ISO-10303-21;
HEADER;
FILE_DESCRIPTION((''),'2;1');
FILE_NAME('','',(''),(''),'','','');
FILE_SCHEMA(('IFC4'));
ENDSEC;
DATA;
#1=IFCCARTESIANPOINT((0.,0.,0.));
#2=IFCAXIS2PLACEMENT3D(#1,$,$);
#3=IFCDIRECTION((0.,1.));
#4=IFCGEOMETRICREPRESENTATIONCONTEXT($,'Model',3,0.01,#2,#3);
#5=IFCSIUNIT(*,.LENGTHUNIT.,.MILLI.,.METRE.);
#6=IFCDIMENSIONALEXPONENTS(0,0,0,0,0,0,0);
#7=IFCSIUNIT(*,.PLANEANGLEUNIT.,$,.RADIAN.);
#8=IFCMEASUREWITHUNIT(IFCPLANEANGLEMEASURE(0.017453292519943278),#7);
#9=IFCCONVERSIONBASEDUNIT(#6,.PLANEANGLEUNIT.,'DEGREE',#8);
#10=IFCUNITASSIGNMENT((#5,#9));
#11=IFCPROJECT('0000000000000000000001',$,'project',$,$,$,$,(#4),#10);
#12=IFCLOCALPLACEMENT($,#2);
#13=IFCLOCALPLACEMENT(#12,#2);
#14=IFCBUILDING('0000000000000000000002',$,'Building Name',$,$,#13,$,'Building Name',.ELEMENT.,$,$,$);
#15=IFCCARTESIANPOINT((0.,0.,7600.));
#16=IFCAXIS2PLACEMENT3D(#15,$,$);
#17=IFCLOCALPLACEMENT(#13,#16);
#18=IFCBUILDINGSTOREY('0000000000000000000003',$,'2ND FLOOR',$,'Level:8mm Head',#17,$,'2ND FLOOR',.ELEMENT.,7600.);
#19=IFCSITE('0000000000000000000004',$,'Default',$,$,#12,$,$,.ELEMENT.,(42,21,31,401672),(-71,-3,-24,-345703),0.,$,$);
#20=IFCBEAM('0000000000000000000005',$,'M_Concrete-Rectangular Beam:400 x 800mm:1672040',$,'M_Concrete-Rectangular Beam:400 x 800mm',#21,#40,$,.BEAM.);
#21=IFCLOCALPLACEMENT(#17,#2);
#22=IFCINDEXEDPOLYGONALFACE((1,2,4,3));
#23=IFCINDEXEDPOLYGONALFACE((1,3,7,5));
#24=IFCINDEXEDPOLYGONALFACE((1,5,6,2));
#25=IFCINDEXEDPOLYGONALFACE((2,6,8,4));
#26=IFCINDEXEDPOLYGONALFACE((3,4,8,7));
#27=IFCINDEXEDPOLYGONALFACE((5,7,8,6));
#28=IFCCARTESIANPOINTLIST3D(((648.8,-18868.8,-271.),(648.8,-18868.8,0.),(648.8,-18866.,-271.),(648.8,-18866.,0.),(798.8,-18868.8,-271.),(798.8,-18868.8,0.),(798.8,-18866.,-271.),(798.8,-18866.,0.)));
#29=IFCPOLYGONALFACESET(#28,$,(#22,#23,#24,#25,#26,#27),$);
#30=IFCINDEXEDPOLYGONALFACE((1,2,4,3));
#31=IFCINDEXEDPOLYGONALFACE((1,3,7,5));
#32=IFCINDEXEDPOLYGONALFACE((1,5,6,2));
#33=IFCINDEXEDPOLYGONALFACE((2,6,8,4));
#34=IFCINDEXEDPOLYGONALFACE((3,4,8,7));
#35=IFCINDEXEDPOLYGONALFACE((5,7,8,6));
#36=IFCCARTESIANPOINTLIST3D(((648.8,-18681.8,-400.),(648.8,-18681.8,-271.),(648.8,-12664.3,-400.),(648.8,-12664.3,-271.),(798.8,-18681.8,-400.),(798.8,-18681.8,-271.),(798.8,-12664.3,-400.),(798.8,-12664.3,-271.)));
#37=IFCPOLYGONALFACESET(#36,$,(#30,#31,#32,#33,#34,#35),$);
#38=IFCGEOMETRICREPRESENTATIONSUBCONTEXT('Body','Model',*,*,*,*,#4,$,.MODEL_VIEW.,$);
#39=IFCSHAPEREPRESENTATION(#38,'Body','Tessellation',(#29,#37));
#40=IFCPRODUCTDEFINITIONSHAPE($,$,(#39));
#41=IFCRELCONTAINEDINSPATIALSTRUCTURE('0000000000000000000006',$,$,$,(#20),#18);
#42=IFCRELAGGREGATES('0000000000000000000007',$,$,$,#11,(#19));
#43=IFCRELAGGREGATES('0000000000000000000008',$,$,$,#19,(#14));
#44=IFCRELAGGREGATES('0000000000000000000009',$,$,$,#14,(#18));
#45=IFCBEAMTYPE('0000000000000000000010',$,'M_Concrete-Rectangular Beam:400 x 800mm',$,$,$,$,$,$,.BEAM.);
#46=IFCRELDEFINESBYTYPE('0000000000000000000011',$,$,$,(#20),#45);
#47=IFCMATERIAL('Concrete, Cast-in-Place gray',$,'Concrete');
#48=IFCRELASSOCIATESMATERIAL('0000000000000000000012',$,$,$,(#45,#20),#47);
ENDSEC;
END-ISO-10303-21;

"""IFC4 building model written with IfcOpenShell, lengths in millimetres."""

from ifc_helpers import new_model, entity, si_unit, converted_unit, direction, frame, origin, place, context, subcontext, project, spatial, indexed_curve, outline, extrude, source, transform, mapped, material, type_object, type_shapes, element, save


model = new_model("IFC4")

# Units and contexts
model_context = context("Model", 3, precision=0.01, world=origin(), true_north=direction((0.0, 1.0)))
body_context = subcontext(model_context, "Body", "Model", "MODEL_VIEW")
ifc_project = project(units=[si_unit("LENGTHUNIT", "METRE", prefix="MILLI"), converted_unit("PLANEANGLEUNIT", "DEGREE", entity("IfcPlaneAngleMeasure", 0.017453292519943278), si_unit("PLANEANGLEUNIT", "RADIAN"), dimensions=[0, 0, 0, 0, 0, 0, 0])], contexts=[model_context])

# Site, building, storey
site_placement = place(None, origin())
site = spatial("IfcSite", under=ifc_project, at=site_placement, Name="Default", CompositionType="ELEMENT", RefLatitude=(42, 21, 31, 401672), RefLongitude=(-71, -3, -24, -345703), RefElevation=0.0)
building_placement = place(site_placement, origin())
building = spatial("IfcBuilding", under=site, at=building_placement, Name="Building Name", LongName="Building Name", CompositionType="ELEMENT")
storey_placement = place(building_placement, frame((0.0, 0.0, 7600.0)))
storey = spatial("IfcBuildingStorey", under=building, at=storey_placement, Name="2ND FLOOR", ObjectType="Level:8mm Head", LongName="2ND FLOOR", CompositionType="ELEMENT", Elevation=7600.0)

# Shared definitions
ifc_material_1 = material(Name="Concrete, Cast-in-Place gray", Category="Concrete")

# Beam
beam_type_1 = type_object("IfcBeamType", Name="M_Concrete-Rectangular Beam:400 x 800mm", PredefinedType="BEAM", material=ifc_material_1)
shared_shape_1 = source(origin(), body_context, "Body", "SweptSolid", [
    extrude(outline(indexed_curve([(-75.0, -135.5), (75.0, -135.5), (75.0, 135.5), (-75.0, 135.5), (-75.0, -135.5)], self_intersect=False)), frame((723.8, -18866.0, 7464.5), z_axis=(0.0, -1.0, 0.0), x_axis=(-1.0, 0.0, 0.0)), (0.0, 0.0, 1.0), 2.8),
    extrude(outline(indexed_curve([(-75.0, -64.5), (75.0, -64.5), (75.0, 64.5), (-75.0, 64.5), (-75.0, -64.5)], self_intersect=False)), frame((723.8, -12664.3, 7264.5), z_axis=(0.0, -1.0, 0.0), x_axis=(-1.0, 0.0, 0.0)), (0.0, 0.0, 1.0), 6017.5),
])
type_shapes(beam_type_1, [shared_shape_1])
beam_1_placement = place(storey_placement, frame((0.0, 0.0, -7600.0)))
element("IfcBeam", 1, at=beam_1_placement, inside=storey, type_object=beam_type_1, material=ifc_material_1, Name="M_Concrete-Rectangular Beam:400 x 800mm:1672040", ObjectType="M_Concrete-Rectangular Beam:400 x 800mm", PredefinedType="BEAM", context=body_context, shape_type="MappedRepresentation", body=[
    mapped(shared_shape_1, transform((0.0, 0.0, 0.0), scale=1.0)),
])

save(model, "model.ifc")
